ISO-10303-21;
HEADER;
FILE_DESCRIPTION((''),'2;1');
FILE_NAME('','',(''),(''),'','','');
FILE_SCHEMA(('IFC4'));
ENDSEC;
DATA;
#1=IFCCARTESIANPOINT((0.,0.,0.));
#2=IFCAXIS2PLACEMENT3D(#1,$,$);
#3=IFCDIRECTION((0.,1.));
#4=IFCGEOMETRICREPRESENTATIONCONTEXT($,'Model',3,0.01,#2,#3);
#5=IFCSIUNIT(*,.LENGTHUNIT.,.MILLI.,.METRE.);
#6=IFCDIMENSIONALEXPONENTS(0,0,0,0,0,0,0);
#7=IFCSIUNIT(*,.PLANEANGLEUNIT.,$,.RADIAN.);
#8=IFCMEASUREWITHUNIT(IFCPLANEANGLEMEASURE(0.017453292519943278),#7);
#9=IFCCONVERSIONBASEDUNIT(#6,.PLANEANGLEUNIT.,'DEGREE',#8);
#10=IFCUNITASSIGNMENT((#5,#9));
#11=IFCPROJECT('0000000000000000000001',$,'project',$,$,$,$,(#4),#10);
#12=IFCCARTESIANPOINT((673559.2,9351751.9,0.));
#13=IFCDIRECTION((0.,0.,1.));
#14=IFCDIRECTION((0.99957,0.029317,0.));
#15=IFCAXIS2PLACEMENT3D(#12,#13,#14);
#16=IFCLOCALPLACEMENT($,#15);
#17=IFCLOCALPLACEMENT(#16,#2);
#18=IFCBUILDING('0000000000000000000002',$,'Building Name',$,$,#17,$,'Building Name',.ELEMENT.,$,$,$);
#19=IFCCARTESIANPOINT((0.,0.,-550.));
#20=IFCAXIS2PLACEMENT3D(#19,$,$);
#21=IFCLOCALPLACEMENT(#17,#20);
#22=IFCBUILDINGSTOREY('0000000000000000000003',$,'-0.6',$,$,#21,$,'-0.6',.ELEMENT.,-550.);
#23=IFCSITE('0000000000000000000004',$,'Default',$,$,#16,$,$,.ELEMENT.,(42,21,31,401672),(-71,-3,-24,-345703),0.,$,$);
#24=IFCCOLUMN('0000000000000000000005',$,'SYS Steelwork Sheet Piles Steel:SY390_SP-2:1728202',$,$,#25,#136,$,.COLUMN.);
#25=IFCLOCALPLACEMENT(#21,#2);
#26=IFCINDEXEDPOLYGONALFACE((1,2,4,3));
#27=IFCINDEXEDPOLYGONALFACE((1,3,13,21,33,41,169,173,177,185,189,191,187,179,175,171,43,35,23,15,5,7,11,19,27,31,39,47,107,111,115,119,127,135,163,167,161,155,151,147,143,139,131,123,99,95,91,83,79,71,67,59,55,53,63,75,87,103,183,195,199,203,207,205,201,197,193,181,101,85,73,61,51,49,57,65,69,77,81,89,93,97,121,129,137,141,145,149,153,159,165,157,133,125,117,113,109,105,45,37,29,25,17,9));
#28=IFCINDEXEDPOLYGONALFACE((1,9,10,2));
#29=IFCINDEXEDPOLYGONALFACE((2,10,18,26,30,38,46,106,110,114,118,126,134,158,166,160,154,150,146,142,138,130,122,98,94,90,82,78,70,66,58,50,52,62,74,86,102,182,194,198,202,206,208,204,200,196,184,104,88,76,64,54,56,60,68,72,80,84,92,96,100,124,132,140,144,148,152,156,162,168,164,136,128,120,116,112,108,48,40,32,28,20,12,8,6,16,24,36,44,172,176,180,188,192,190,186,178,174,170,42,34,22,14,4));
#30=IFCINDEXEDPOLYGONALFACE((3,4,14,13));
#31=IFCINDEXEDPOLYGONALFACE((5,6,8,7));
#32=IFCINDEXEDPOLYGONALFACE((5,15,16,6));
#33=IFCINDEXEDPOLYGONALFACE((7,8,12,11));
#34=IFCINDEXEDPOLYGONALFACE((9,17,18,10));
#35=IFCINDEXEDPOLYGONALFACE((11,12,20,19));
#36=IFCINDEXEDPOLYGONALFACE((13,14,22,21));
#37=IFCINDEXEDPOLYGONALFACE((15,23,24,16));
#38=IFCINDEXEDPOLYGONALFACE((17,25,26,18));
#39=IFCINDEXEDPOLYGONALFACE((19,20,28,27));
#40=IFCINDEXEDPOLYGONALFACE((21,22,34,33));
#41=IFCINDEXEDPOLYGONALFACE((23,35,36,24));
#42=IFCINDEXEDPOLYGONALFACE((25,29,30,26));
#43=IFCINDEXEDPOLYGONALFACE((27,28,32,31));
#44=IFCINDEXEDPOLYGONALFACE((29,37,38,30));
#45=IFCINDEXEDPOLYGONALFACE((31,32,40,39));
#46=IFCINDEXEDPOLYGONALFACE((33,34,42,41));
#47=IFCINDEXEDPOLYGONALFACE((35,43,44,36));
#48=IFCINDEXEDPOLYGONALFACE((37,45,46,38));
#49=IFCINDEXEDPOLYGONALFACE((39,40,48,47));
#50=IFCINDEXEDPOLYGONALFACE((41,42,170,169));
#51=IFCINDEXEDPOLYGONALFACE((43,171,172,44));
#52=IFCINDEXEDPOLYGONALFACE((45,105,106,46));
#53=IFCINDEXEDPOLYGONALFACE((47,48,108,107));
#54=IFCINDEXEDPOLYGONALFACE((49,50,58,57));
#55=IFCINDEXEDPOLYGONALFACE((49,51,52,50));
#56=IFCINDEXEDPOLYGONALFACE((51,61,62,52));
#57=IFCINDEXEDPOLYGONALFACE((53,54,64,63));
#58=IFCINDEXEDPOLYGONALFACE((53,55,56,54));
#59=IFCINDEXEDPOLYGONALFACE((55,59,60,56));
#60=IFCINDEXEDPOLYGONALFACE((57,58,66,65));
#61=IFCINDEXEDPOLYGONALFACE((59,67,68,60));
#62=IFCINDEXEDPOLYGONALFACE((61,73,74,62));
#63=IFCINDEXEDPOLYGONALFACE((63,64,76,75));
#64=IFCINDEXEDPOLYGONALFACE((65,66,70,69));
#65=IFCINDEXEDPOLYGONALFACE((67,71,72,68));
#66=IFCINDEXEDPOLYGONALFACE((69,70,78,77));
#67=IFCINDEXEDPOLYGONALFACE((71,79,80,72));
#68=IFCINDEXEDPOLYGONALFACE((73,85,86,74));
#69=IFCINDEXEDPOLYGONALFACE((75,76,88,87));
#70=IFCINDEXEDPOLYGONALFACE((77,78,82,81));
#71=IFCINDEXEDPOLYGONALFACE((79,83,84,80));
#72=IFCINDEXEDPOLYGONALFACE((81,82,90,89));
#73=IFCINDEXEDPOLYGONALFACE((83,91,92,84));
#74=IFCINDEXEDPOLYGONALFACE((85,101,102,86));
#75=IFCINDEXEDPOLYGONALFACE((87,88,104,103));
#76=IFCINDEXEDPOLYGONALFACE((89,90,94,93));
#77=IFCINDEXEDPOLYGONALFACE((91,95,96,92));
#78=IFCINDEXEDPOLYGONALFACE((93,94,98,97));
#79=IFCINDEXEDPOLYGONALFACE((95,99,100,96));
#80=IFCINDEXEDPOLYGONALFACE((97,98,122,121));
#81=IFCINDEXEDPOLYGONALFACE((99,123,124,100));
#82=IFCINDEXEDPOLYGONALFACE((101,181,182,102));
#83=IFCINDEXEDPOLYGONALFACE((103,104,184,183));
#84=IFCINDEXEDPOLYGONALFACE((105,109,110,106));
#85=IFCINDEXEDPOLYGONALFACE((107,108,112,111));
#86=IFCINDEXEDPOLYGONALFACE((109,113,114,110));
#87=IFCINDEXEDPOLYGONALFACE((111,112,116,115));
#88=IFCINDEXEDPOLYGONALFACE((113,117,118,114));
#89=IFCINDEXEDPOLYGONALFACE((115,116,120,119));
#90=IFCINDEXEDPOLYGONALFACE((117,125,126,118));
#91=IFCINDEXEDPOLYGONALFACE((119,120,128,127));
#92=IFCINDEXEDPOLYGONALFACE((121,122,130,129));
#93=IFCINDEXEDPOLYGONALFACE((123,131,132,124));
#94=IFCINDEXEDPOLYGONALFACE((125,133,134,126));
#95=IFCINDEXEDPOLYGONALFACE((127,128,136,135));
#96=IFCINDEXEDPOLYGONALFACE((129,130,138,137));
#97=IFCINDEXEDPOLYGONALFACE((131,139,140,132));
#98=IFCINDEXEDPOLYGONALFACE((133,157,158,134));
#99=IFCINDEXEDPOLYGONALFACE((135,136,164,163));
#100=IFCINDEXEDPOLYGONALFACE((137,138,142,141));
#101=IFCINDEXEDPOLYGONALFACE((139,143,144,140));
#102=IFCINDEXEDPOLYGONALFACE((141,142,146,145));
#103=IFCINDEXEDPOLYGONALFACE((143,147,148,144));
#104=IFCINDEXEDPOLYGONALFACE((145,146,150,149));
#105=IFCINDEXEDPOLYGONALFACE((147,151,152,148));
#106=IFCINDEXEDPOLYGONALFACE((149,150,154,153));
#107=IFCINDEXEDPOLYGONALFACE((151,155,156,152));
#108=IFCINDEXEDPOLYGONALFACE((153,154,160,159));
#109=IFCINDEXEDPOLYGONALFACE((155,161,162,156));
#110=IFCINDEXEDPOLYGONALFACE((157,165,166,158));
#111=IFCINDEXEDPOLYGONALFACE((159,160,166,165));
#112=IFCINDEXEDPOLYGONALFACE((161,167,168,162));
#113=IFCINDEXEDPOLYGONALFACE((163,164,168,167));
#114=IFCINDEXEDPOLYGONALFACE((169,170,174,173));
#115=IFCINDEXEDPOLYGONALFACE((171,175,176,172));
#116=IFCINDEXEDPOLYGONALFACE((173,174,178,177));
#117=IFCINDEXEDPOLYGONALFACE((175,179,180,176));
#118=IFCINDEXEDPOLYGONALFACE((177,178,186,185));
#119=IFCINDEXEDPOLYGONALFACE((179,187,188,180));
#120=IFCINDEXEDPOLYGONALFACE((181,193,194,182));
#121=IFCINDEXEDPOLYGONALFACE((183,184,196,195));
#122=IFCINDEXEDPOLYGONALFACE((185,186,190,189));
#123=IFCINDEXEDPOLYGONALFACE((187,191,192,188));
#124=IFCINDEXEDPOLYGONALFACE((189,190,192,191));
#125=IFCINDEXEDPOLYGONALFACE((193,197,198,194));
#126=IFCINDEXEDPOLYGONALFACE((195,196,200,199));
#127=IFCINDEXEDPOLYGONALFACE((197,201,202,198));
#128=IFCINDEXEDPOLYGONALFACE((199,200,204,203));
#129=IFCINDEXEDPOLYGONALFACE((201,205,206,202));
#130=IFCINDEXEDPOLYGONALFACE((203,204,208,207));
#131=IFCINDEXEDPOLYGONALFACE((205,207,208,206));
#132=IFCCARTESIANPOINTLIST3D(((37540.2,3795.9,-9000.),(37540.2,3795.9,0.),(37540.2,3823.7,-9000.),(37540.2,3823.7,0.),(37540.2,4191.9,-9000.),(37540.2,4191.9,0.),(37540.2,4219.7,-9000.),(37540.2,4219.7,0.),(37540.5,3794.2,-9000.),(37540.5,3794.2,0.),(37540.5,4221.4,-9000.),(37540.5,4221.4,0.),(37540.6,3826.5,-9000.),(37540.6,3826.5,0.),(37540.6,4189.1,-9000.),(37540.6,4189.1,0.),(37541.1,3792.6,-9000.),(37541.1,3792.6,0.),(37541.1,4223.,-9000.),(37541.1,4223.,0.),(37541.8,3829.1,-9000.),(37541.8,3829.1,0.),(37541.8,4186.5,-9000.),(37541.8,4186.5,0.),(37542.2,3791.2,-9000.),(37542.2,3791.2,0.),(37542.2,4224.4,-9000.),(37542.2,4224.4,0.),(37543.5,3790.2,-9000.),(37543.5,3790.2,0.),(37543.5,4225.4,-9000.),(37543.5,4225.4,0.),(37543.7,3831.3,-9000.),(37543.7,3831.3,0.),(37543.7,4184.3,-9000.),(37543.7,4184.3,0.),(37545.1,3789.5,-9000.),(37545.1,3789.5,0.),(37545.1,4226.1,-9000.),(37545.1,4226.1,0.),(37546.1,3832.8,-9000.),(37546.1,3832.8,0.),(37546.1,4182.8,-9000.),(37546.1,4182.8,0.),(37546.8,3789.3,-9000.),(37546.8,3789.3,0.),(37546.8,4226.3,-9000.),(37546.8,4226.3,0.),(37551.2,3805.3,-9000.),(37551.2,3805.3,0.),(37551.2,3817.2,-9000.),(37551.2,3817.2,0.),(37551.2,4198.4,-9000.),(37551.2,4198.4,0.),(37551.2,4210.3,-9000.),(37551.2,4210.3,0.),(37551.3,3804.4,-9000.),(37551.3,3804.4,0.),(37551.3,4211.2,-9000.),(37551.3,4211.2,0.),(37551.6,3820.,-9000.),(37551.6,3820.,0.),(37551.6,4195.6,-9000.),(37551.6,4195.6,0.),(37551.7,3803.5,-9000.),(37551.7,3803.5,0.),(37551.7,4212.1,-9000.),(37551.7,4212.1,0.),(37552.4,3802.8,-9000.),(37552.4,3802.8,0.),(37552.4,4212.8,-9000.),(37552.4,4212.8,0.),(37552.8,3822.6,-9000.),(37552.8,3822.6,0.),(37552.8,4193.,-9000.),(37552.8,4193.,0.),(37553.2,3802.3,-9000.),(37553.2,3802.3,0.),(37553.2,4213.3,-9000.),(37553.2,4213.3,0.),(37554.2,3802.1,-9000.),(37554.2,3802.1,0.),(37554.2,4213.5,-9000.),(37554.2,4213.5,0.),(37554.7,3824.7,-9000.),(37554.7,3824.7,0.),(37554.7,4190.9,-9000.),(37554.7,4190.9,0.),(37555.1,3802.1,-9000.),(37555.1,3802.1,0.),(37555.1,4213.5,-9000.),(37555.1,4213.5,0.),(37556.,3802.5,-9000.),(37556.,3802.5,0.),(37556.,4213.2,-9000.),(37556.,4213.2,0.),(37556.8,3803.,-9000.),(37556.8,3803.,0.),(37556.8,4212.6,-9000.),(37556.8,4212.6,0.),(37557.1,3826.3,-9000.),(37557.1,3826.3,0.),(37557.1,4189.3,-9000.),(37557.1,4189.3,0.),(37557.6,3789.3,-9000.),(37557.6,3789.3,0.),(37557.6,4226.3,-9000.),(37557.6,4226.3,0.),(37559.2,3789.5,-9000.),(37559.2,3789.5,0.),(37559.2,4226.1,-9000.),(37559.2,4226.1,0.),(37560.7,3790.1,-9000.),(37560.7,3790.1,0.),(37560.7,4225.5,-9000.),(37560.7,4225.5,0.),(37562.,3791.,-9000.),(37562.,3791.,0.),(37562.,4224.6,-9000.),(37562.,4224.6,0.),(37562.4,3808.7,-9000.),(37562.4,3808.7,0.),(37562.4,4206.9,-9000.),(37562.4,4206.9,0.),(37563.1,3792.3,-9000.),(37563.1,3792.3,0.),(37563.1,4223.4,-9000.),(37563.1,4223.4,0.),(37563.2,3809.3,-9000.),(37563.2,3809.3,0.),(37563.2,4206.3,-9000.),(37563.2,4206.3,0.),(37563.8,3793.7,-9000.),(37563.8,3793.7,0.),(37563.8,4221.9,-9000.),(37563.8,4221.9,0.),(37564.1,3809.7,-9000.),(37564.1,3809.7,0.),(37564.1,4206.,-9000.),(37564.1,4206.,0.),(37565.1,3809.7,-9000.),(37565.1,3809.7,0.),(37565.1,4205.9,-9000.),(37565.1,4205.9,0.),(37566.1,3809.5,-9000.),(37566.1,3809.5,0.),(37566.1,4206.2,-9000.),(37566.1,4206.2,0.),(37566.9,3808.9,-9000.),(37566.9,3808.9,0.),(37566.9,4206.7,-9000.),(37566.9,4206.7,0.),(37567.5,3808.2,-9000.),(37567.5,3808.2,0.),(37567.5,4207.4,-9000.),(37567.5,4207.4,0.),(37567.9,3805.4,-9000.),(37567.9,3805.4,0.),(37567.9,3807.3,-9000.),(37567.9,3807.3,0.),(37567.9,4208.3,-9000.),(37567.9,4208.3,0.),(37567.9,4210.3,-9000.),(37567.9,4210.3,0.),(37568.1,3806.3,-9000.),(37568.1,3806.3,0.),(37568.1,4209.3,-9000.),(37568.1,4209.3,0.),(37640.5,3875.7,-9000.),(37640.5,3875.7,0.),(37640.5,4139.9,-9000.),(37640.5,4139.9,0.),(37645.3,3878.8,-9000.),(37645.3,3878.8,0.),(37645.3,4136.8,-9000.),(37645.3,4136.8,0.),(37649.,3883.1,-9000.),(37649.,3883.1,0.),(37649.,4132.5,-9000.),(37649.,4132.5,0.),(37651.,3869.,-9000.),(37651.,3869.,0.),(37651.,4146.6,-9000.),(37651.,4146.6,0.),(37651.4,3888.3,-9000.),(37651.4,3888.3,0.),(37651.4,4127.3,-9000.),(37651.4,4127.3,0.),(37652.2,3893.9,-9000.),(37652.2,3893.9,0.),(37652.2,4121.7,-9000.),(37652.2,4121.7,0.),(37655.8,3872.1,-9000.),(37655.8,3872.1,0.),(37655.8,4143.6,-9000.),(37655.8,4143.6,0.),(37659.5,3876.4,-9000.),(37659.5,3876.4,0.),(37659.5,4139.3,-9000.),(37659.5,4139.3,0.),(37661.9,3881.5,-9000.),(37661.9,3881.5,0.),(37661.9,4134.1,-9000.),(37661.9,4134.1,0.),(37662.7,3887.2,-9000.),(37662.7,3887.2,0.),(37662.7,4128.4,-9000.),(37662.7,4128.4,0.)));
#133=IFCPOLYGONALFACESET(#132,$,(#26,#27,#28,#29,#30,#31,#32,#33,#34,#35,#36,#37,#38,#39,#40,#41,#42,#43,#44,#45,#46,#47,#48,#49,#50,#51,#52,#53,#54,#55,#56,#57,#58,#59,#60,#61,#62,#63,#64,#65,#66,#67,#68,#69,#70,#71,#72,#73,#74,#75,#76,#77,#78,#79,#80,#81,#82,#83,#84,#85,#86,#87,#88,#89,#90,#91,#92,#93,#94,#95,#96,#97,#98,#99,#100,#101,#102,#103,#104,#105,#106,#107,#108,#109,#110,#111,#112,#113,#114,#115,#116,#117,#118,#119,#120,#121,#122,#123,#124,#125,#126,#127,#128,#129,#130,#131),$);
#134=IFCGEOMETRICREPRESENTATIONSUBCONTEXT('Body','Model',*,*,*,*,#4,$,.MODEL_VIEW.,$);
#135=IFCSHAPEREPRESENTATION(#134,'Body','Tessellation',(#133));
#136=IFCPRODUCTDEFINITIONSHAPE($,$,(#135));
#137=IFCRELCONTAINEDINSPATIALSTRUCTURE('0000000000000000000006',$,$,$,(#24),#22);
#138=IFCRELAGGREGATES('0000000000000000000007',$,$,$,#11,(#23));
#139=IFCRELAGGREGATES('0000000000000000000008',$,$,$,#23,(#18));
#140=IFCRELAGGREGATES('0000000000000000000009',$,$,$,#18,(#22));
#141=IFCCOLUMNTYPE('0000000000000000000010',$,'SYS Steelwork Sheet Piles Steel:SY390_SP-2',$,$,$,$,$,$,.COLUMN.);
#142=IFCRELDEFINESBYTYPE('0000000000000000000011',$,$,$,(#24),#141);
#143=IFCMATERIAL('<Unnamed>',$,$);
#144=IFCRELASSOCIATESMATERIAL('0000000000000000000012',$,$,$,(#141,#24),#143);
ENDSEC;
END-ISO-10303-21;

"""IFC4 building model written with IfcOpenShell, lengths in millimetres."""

from ifc_helpers import new_model, entity, si_unit, converted_unit, direction, frame, origin, place, context, subcontext, project, spatial, line, arc, indexed_curve, outline, extrude, source, transform, mapped, material, type_object, type_shapes, element, save


model = new_model("IFC4")

# Units and contexts
model_context = context("Model", 3, precision=0.01, world=origin(), true_north=direction((0.0, 1.0)))
body_context = subcontext(model_context, "Body", "Model", "MODEL_VIEW")
ifc_project = project(units=[si_unit("LENGTHUNIT", "METRE", prefix="MILLI"), converted_unit("PLANEANGLEUNIT", "DEGREE", entity("IfcPlaneAngleMeasure", 0.017453292519943278), si_unit("PLANEANGLEUNIT", "RADIAN"), dimensions=[0, 0, 0, 0, 0, 0, 0])], contexts=[model_context])

# Site, building, storey
site_placement = place(None, frame((673559.2, 9351751.9, 0.0), z_axis=(0.0, 0.0, 1.0), x_axis=(0.99957, 0.029317, 0.0)))
site = spatial("IfcSite", under=ifc_project, at=site_placement, Name="Default", CompositionType="ELEMENT", RefLatitude=(42, 21, 31, 401672), RefLongitude=(-71, -3, -24, -345703), RefElevation=0.0)
building_placement = place(site_placement, origin())
building = spatial("IfcBuilding", under=site, at=building_placement, Name="Building Name", LongName="Building Name", CompositionType="ELEMENT")
storey_placement = place(building_placement, frame((0.0, 0.0, -550.0)))
storey = spatial("IfcBuildingStorey", under=building, at=storey_placement, Name="-0.6", LongName="-0.6", CompositionType="ELEMENT", Elevation=-550.0)

# Column
ifc_material_1 = material(Name="<Unnamed>")
column_type = type_object("IfcColumnType", Name="SYS Steelwork Sheet Piles Steel:SY390_SP-2", PredefinedType="COLUMN", material=ifc_material_1)
shared_shape = source(origin(), body_context, "Body", "SweptSolid", [
    extrude(outline(indexed_curve([(-120.6, 84.7), (-131.4, 81.6), (-138.8, 73.0), (-181.5, -20.9), (-185.2, -25.2), (-190.6, -26.8), (-202.5, -26.8), (-205.5, -24.8), (-204.8, -21.2), (-199.1, -15.5), (-198.6, -11.5), (-202.5, -10.1), (-214.1, -14.2), (-217.3, -16.6), (-218.5, -20.4), (-218.5, -31.2), (-216.6, -35.8), (-211.9, -37.8), (-184.1, -37.8), (-178.7, -36.2), (-175.0, -31.9), (-132.1, 62.5), (-124.7, 71.1), (-113.9, 74.2), (113.9, 74.2), (124.7, 71.1), (132.1, 62.5), (175.0, -31.9), (178.7, -36.2), (184.1, -37.8), (211.9, -37.8), (216.6, -35.8), (218.5, -31.2), (218.5, -20.4), (217.3, -16.6), (214.1, -14.2), (202.5, -10.1), (198.6, -11.5), (199.1, -15.5), (204.8, -21.2), (205.5, -24.8), (202.5, -26.8), (190.6, -26.8), (185.2, -25.2), (181.5, -20.9), (138.8, 73.0), (131.4, 81.6), (120.6, 84.7)], segments=[arc(1, 2, 3), line(3, 4), arc(4, 5, 6), line(6, 7), arc(7, 8, 9), line(9, 10), arc(10, 11, 12), line(12, 13), arc(13, 14, 15), line(15, 16), arc(16, 17, 18), line(18, 19), arc(19, 20, 21), line(21, 22), arc(22, 23, 24), line(24, 25), arc(25, 26, 27), line(27, 28), arc(28, 29, 30), line(30, 31), arc(31, 32, 33), line(33, 34), arc(34, 35, 36), line(36, 37), arc(37, 38, 39), line(39, 40), arc(40, 41, 42), line(42, 43), arc(43, 44, 45), line(45, 46), arc(46, 47, 48), line(48, 1)], self_intersect=False)), frame((0.0, 15.3, -9550.0)), (0.0, 0.0, 1.0), 9000.0),
])
type_shapes(column_type, [shared_shape])
for number, where, z_axis, x_axis, name in (
    (1, (37562.7, 4007.8, 550.0), (0.0, 0.0, 1.0), (0.0, -1.0, 0.0), "SYS Steelwork Sheet Piles Steel:SY390_SP-2:1728202"),
):
    element("IfcColumn", number, at=place(storey_placement, frame(where, z_axis=z_axis, x_axis=x_axis)), inside=storey, type_object=column_type, material=ifc_material_1, Name=name, PredefinedType="COLUMN", context=body_context, shape_type="MappedRepresentation", body=[
        mapped(shared_shape, transform((0.0, 0.0, 0.0), scale=1.0)),
    ])

save(model, "model.ifc")
